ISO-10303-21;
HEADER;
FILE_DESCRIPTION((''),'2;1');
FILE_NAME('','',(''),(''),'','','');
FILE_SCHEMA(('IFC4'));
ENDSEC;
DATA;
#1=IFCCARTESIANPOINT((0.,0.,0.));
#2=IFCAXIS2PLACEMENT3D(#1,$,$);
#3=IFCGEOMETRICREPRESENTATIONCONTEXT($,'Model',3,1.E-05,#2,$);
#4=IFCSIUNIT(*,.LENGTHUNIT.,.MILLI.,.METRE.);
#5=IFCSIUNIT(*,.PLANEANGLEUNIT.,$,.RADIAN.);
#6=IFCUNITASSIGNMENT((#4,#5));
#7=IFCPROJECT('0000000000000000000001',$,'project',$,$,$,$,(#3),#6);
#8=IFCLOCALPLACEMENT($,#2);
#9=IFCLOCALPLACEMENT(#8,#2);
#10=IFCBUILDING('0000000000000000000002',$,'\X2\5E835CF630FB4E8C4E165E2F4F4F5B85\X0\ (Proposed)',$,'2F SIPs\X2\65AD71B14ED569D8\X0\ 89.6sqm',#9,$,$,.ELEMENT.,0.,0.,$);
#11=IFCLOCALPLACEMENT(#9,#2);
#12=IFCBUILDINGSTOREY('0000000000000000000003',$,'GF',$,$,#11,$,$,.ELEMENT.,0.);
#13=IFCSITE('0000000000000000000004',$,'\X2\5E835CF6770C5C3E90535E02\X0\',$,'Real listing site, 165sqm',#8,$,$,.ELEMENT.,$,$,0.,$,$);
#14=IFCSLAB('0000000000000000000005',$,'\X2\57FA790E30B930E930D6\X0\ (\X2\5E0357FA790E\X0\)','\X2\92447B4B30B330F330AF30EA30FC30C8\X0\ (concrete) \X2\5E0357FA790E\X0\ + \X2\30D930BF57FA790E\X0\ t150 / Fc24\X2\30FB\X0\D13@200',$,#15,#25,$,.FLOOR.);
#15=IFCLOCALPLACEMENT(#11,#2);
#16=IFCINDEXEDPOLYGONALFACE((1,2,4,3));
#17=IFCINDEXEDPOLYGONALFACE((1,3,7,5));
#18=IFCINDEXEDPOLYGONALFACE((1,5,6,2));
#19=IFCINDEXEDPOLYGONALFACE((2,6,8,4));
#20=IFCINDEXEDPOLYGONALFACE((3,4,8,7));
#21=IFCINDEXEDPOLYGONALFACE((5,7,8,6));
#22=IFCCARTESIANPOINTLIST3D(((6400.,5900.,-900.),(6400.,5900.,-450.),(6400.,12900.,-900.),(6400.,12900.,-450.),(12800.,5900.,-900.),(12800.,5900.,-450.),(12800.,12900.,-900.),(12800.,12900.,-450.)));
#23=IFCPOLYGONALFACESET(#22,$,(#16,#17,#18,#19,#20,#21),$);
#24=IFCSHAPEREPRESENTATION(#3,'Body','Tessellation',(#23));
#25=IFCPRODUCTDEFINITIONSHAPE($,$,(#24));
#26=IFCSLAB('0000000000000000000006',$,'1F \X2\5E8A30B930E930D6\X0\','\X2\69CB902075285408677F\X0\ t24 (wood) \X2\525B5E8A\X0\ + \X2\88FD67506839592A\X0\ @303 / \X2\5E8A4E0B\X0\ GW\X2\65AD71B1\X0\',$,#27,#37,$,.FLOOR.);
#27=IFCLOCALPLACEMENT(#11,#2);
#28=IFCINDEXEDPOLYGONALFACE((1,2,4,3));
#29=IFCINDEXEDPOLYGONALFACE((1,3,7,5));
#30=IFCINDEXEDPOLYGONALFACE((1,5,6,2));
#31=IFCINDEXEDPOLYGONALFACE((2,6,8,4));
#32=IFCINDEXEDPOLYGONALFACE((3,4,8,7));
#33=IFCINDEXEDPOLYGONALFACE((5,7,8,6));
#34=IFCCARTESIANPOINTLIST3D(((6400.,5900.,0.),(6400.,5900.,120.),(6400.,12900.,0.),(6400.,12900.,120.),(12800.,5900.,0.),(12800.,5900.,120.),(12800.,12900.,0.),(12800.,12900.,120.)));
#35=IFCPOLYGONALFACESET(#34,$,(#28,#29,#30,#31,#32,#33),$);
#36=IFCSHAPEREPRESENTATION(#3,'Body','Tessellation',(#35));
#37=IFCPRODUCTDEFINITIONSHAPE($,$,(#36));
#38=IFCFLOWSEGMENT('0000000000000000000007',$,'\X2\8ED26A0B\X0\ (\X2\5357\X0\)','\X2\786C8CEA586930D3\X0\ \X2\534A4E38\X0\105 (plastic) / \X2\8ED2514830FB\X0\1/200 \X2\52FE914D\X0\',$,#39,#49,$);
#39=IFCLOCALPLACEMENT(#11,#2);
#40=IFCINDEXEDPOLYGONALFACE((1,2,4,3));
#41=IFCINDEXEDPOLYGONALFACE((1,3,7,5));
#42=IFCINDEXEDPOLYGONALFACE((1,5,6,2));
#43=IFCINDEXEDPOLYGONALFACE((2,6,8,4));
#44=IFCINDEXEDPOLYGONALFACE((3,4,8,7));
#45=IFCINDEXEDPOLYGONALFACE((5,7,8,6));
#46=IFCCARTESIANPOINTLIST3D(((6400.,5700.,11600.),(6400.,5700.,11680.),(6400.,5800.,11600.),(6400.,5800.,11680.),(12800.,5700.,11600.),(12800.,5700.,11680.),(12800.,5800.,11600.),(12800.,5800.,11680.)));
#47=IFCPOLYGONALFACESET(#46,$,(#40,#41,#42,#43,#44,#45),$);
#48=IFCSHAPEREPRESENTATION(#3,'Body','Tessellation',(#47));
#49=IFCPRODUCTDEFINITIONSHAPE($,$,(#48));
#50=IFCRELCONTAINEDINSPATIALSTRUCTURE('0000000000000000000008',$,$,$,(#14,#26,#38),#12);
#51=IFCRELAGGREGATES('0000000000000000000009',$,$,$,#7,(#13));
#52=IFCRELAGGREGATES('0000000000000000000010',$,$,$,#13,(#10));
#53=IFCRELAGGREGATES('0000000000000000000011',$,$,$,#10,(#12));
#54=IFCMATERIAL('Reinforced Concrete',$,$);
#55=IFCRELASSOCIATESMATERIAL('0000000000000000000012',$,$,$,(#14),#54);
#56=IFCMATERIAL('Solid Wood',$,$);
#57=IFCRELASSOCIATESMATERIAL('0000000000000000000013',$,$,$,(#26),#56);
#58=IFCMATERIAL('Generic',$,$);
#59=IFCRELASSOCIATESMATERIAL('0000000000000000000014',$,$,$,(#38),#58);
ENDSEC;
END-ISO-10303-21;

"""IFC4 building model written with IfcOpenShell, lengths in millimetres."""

from ifc_helpers import new_model, si_unit, frame, frame_2d, origin, place, context, project, spatial, rectangle, extrude, material, element, save


model = new_model("IFC4")

# Units and contexts
model_context = context("Model", 3, precision=1e-05, world=origin())
ifc_project = project(units=[si_unit("LENGTHUNIT", "METRE", prefix="MILLI"), si_unit("PLANEANGLEUNIT", "RADIAN")], contexts=[model_context])

# Site, building, storey
site_placement = place(None, origin())
site = spatial("IfcSite", under=ifc_project, at=site_placement, Name="広島県尾道市", ObjectType="Real listing site, 165sqm", CompositionType="ELEMENT", RefElevation=0.0)
building_placement = place(site_placement, origin())
building = spatial("IfcBuilding", under=site, at=building_placement, Name="広島・二世帯住宅 (Proposed)", ObjectType="2F SIPs断熱仕様 89.6sqm", CompositionType="ELEMENT", ElevationOfRefHeight=0.0, ElevationOfTerrain=0.0)
storey_placement = place(building_placement, origin())
storey = spatial("IfcBuildingStorey", under=building, at=storey_placement, Name="GF", CompositionType="ELEMENT", Elevation=0.0)

# Shared definitions
ifc_material_1 = material(Name="Solid Wood")

# Slabs
ifc_material_2 = material(Name="Reinforced Concrete")
slab_1_placement = place(storey_placement, frame((3200.0, 2950.0, -450.0)))
element("IfcSlab", 1, at=slab_1_placement, inside=storey, material=ifc_material_2, Name="基礎スラブ (布基礎)", Description="鉄筋コンクリート (concrete) 布基礎 + ベタ基礎 t150 / Fc24・D13@200", PredefinedType="FLOOR", context=model_context, shape_type="SweptSolid", body=[
    extrude(rectangle(XDim=6400.0, YDim=7000.0, at=frame_2d((3200.0, 3500.0))), frame((3200.0, 2950.0, -450.0)), (0.0, 0.0, 1.0), 450.0),
])
slab_2_placement = place(storey_placement, frame((3200.0, 2950.0, 0.0)))
element("IfcSlab", 2, at=slab_2_placement, inside=storey, material=ifc_material_1, Name="1F 床スラブ", Description="構造用合板 t24 (wood) 剛床 + 製材根太 @303 / 床下 GW断熱", PredefinedType="FLOOR", context=model_context, shape_type="SweptSolid", body=[
    extrude(rectangle(XDim=6400.0, YDim=7000.0, at=frame_2d((3200.0, 3500.0))), frame((3200.0, 2950.0, 0.0)), (0.0, 0.0, 1.0), 120.0),
])

# Flow segment
ifc_material_3 = material(Name="Generic")
flow_segment_1_placement = place(storey_placement, frame((3200.0, 2850.0, 5800.0)))
element("IfcFlowSegment", 3, at=flow_segment_1_placement, inside=storey, material=ifc_material_3, Name="軒樋 (南)", Description="硬質塩ビ 半丸105 (plastic) / 軒先・1/200 勾配", context=model_context, shape_type="SweptSolid", body=[
    extrude(rectangle(XDim=6400.0, YDim=100.0, at=frame_2d((3200.0, 50.0))), frame((3200.0, 2850.0, 5800.0)), (0.0, 0.0, 1.0), 80.0),
])

save(model, "model.ifc")
